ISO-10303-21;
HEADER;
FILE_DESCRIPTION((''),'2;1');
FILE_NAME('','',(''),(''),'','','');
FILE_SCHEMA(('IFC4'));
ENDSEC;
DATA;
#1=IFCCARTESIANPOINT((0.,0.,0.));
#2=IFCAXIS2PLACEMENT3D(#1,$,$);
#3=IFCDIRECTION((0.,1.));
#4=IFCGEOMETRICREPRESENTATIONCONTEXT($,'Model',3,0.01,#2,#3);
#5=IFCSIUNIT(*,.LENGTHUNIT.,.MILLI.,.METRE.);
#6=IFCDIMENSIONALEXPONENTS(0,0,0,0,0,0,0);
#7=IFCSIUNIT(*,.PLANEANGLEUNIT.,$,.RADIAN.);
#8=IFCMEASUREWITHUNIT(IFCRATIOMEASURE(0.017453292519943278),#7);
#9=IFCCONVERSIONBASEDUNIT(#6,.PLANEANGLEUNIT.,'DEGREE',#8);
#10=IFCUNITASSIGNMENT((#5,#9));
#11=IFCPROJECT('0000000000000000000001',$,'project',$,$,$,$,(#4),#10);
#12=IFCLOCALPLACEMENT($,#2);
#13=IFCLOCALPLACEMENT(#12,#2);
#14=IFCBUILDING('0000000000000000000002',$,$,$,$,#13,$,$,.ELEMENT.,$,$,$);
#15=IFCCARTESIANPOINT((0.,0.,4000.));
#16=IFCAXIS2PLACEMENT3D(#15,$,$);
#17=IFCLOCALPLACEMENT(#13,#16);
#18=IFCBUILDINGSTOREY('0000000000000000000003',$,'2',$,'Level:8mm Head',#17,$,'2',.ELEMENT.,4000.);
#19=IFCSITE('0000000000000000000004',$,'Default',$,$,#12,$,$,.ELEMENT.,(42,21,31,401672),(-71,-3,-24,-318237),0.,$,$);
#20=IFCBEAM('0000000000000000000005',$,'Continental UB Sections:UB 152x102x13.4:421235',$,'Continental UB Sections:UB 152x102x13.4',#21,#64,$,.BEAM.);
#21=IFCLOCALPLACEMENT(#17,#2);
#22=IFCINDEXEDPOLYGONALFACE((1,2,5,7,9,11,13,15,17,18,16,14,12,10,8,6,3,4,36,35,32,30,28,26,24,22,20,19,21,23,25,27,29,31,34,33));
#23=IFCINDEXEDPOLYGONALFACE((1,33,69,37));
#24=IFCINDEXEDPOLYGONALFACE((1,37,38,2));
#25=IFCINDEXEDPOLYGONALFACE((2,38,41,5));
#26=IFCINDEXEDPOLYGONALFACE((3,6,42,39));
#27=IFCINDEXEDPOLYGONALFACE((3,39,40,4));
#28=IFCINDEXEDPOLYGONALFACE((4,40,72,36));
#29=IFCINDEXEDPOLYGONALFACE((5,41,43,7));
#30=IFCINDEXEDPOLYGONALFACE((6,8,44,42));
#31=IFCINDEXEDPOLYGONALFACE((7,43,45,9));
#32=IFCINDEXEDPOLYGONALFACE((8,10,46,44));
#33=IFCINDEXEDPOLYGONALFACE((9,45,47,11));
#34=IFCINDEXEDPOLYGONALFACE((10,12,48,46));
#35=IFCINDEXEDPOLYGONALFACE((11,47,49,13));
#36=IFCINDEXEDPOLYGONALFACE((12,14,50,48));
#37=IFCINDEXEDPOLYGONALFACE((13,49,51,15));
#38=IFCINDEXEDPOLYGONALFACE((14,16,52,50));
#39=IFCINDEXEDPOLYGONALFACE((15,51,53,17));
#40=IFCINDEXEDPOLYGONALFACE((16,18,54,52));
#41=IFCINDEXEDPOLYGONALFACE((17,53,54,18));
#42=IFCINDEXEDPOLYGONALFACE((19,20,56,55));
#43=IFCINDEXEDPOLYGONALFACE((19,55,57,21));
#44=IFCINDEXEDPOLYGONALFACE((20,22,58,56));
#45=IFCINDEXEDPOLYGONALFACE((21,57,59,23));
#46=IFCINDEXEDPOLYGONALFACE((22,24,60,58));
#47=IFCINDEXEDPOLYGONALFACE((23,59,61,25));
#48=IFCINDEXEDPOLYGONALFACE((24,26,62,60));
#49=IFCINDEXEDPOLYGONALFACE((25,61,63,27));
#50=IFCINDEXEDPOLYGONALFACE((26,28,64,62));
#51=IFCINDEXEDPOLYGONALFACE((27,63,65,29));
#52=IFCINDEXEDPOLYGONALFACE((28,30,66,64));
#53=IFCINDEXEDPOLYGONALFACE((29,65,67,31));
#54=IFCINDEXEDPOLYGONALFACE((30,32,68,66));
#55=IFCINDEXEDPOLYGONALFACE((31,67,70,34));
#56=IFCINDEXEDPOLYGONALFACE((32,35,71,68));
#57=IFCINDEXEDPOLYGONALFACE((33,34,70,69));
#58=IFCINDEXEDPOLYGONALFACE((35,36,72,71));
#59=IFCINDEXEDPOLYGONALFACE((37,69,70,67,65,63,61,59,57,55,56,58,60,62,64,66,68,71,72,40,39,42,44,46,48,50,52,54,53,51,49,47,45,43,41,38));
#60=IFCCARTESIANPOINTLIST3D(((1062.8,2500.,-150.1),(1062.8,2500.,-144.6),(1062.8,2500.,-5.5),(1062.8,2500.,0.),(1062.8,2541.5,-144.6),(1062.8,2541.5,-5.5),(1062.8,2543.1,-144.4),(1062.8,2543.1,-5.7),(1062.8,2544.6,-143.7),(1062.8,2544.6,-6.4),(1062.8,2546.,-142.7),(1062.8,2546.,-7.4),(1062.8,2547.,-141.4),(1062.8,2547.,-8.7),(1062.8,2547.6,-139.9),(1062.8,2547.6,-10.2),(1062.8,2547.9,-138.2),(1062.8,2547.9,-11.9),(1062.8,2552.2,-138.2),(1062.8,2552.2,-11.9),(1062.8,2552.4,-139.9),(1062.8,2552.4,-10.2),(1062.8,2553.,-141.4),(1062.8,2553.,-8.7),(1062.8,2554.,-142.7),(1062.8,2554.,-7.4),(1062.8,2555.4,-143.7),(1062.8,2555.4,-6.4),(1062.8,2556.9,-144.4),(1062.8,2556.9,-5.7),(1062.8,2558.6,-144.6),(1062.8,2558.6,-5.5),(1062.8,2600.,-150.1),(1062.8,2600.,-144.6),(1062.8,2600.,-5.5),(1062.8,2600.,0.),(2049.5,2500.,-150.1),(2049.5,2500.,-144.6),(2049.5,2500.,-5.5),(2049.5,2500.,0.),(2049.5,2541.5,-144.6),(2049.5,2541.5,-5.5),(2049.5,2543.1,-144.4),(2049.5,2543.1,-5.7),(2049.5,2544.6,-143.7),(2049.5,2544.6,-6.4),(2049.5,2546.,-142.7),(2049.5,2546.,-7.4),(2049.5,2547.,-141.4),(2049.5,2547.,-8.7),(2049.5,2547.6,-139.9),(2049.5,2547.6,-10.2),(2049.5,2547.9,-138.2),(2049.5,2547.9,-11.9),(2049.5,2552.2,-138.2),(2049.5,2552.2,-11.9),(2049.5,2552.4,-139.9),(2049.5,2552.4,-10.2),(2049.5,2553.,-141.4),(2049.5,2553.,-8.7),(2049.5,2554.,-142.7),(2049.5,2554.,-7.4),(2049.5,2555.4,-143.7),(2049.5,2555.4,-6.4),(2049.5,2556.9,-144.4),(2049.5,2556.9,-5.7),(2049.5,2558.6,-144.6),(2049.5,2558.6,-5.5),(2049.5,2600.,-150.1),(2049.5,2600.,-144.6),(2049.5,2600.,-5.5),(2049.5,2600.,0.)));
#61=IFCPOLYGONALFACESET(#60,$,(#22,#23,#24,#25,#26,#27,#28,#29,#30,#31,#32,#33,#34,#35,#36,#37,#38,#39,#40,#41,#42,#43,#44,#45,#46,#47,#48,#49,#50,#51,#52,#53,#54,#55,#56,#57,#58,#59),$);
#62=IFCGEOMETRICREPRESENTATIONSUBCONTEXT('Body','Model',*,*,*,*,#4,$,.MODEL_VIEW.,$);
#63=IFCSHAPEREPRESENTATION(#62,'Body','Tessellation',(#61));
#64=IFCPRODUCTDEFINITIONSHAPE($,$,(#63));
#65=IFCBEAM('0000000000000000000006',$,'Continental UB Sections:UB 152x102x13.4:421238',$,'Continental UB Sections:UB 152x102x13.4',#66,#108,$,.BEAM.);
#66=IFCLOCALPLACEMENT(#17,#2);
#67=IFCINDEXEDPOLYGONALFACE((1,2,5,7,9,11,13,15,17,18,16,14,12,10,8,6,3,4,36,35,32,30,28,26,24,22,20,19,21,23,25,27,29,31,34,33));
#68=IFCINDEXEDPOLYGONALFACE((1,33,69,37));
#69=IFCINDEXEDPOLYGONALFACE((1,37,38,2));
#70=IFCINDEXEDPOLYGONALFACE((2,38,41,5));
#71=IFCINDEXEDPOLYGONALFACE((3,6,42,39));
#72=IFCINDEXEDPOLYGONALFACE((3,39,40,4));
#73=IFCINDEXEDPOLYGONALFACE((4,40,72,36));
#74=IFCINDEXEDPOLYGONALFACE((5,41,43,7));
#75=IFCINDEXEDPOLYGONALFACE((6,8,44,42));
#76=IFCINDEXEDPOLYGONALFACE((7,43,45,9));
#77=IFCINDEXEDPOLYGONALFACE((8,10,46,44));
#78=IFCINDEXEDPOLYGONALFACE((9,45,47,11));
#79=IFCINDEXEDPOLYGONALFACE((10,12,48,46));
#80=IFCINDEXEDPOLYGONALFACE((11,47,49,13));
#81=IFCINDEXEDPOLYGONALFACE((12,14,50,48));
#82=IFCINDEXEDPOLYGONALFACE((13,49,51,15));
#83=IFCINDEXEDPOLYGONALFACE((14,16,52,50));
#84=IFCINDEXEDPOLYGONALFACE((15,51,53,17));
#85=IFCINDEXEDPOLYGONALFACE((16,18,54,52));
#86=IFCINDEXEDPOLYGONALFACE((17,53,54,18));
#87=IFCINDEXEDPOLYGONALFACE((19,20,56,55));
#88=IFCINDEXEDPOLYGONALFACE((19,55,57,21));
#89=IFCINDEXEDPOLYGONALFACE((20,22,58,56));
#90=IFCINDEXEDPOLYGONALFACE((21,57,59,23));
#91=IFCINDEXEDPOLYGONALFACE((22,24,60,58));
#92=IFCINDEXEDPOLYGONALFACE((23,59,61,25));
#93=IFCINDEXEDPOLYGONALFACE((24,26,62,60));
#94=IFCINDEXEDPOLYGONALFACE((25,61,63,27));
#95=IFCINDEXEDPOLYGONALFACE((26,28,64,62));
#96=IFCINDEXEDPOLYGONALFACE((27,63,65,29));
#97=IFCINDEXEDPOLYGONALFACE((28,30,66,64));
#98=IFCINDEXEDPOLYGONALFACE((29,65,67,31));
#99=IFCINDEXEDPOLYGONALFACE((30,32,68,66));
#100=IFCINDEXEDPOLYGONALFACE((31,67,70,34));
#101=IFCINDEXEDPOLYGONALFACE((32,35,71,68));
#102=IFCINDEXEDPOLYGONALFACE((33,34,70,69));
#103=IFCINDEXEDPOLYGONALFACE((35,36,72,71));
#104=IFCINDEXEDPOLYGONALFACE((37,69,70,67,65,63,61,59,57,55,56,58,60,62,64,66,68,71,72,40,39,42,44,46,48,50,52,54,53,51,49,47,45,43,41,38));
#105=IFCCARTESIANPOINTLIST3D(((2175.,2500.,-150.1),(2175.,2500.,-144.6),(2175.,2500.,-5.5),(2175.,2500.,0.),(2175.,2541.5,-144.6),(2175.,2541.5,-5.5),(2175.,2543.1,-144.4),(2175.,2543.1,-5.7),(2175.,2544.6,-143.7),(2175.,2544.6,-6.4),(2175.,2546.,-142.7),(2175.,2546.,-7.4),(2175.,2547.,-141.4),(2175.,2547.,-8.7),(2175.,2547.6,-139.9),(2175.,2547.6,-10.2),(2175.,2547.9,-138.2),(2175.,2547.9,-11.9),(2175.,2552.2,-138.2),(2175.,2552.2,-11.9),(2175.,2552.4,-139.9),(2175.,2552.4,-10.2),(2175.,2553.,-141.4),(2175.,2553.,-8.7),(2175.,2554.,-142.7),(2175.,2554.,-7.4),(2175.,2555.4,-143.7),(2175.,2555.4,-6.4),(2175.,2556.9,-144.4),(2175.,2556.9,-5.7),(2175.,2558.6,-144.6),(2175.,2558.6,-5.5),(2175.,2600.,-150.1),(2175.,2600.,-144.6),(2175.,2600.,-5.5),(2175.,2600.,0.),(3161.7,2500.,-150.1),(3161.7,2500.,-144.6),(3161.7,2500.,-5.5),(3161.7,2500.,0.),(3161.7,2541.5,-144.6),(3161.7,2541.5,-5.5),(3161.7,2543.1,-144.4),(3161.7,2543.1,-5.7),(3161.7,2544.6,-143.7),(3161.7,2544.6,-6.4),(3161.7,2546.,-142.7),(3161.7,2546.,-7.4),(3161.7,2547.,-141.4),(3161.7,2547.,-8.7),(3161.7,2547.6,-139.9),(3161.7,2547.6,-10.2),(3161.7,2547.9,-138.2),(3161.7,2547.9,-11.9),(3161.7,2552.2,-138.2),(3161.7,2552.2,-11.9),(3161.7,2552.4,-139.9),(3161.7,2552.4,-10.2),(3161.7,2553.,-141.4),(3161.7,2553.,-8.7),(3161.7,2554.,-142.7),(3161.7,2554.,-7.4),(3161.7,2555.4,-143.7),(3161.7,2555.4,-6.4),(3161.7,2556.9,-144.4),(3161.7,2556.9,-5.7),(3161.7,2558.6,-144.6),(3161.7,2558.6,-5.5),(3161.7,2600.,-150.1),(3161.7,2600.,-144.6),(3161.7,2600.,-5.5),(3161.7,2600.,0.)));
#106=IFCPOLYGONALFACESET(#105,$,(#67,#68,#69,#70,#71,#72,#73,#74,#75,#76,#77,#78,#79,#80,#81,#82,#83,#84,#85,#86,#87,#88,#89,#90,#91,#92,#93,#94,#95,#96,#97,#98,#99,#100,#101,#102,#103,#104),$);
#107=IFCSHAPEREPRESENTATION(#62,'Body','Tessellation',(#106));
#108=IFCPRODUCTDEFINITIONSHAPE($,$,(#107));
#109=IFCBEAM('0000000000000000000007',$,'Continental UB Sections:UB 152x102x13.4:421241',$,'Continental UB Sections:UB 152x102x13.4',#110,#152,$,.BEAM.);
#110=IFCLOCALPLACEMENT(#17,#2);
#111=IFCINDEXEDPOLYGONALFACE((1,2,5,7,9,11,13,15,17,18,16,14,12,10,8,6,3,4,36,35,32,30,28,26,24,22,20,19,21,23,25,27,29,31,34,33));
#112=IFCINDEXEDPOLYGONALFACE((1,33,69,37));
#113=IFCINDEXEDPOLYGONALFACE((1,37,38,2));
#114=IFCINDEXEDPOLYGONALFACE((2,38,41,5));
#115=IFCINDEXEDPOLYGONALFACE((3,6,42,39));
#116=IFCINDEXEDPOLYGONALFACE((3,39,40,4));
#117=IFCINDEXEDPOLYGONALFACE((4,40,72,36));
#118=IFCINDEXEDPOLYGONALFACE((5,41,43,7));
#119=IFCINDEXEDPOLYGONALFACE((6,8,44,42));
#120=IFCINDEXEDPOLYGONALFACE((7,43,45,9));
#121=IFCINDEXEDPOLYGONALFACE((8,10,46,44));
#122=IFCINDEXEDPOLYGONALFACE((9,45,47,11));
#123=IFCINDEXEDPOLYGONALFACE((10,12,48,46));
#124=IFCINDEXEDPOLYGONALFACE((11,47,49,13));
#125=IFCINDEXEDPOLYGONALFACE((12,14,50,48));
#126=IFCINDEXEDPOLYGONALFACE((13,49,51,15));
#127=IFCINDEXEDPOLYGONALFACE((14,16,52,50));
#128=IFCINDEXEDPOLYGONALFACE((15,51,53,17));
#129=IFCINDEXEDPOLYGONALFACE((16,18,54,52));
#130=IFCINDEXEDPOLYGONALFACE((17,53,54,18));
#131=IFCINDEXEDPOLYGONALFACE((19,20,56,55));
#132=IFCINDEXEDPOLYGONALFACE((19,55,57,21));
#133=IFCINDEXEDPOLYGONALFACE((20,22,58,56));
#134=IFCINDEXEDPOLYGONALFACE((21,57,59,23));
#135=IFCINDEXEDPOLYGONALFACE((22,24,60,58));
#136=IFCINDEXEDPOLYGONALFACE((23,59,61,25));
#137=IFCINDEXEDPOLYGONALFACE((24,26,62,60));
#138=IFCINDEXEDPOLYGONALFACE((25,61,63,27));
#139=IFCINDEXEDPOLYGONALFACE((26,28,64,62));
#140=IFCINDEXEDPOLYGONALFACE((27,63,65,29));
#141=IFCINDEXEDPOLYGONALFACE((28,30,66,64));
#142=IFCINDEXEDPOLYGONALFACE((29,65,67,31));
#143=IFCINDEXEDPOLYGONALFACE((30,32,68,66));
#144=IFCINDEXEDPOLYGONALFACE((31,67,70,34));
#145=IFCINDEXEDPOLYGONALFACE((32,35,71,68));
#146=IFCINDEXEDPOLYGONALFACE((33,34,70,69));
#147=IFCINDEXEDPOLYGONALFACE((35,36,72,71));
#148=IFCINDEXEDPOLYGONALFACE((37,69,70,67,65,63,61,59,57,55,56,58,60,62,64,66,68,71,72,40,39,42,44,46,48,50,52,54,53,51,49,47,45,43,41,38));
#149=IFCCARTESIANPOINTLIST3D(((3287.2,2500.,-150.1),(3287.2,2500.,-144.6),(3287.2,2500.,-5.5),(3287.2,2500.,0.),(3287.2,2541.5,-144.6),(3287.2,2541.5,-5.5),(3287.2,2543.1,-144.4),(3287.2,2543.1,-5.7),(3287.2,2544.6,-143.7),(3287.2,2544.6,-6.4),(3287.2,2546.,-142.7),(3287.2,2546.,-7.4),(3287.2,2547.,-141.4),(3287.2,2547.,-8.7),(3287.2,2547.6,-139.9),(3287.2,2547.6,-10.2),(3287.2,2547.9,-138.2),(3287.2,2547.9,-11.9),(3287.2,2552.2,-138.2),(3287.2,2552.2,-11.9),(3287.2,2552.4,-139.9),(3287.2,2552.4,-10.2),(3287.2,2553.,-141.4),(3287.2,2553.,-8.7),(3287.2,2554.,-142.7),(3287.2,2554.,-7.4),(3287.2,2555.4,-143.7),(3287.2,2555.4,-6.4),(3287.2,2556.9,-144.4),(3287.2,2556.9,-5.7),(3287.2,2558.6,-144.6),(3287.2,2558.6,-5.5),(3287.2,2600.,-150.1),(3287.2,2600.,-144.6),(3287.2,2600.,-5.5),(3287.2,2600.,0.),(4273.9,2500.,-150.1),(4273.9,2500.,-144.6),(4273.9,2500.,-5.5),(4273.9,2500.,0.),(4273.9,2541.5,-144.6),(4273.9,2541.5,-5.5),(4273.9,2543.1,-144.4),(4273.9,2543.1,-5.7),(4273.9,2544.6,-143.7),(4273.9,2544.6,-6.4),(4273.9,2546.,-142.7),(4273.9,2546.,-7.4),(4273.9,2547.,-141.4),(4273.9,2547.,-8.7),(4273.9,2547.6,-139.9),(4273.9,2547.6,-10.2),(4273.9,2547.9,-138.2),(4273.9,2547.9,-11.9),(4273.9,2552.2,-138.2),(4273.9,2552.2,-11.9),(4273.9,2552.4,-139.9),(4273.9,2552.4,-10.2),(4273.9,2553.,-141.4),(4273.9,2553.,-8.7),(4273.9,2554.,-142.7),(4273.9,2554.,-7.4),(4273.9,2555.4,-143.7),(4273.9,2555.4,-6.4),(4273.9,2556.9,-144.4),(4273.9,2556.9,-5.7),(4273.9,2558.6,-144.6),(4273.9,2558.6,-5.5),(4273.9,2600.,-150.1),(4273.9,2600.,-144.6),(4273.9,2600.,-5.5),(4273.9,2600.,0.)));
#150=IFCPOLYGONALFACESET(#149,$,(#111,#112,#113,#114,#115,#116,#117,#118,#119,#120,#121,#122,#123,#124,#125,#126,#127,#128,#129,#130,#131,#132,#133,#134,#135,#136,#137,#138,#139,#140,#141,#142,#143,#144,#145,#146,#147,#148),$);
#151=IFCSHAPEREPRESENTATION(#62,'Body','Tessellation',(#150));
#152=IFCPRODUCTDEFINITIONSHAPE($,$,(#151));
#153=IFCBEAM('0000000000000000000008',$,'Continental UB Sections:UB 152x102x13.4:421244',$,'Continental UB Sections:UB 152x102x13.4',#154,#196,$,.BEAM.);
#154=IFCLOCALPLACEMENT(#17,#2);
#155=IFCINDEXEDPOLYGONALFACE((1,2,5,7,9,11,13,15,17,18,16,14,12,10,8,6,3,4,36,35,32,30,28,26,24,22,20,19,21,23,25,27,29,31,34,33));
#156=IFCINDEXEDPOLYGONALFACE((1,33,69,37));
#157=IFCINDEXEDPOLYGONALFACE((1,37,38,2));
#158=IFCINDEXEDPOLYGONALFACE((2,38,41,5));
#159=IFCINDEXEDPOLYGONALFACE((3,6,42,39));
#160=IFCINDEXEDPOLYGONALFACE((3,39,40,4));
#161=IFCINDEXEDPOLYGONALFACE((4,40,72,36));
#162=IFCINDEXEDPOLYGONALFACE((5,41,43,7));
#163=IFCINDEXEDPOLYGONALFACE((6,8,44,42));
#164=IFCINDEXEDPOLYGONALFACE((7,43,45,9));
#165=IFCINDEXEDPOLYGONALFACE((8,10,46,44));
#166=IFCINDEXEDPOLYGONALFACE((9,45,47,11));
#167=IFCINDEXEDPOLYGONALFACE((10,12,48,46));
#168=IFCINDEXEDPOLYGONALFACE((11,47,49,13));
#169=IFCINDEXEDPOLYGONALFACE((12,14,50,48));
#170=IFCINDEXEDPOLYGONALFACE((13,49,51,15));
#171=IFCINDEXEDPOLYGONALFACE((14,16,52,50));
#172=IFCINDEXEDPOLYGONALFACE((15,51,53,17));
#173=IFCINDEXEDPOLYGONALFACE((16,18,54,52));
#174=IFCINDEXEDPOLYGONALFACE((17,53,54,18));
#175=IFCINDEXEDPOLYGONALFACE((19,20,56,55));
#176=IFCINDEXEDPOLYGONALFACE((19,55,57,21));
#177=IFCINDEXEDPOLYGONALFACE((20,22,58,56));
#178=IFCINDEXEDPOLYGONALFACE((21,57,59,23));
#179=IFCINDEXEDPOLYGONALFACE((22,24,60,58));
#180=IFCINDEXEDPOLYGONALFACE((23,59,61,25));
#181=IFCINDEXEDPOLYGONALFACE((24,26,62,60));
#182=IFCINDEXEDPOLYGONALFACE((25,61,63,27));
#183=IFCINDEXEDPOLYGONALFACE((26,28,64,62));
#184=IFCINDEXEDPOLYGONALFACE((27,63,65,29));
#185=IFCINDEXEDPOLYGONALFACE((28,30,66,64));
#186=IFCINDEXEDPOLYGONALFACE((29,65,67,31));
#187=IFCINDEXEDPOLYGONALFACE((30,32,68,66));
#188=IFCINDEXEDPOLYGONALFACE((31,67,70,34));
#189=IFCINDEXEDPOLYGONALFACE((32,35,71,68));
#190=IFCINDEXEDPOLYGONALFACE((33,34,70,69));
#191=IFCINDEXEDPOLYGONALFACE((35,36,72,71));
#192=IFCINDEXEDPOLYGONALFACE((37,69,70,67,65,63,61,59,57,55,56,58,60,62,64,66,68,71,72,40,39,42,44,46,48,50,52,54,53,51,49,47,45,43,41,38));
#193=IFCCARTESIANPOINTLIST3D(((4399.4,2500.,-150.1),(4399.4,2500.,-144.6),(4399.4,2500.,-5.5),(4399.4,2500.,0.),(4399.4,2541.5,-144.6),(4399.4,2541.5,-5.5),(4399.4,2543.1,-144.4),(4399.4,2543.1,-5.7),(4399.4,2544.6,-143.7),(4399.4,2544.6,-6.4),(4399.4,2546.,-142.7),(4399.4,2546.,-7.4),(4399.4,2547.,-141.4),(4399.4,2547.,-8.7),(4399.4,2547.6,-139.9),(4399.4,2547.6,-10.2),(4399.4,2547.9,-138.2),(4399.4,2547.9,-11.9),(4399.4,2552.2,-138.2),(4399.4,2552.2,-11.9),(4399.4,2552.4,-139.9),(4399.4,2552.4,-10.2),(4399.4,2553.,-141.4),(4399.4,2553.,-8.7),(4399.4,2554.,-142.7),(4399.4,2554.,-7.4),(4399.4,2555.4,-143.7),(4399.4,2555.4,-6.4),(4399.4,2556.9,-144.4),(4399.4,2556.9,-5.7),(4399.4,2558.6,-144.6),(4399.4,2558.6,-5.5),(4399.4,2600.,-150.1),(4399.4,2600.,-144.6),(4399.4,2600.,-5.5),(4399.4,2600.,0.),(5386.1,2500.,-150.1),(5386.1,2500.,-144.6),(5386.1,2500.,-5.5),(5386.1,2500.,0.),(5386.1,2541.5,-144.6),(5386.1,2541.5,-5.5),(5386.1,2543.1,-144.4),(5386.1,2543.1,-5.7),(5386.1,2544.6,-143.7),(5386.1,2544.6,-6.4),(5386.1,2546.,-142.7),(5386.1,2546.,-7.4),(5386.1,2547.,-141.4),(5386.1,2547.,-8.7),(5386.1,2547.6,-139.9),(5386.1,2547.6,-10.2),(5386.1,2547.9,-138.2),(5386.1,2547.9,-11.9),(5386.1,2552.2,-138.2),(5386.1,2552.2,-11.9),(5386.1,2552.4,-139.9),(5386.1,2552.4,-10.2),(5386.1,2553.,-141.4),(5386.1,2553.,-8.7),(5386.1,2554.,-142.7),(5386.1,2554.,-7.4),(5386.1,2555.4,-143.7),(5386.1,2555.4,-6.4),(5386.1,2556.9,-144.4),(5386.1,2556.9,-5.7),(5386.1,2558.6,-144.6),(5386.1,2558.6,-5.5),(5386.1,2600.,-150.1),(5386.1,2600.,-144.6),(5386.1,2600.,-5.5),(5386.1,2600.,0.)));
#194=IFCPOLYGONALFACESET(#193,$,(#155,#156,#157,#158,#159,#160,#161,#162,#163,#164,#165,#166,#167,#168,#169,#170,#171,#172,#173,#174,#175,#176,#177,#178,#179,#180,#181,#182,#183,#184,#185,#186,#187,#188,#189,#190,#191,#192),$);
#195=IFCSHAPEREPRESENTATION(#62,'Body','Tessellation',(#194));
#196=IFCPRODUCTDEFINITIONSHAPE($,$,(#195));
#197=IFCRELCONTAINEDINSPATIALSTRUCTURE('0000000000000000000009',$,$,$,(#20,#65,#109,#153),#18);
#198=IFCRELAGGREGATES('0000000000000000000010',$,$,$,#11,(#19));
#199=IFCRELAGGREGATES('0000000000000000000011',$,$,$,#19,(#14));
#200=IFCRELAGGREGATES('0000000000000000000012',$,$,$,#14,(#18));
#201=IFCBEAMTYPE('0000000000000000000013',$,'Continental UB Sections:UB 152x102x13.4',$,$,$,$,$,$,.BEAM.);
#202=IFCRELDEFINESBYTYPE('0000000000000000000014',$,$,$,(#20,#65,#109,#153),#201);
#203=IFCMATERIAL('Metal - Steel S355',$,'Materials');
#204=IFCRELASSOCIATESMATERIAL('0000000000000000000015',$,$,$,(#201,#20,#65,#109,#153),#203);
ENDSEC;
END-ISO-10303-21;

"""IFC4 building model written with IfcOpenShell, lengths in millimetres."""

from ifc_helpers import new_model, entity, si_unit, converted_unit, direction, frame, origin, place, context, subcontext, project, spatial, line, arc, indexed_curve, outline, extrude, source, transform, mapped, material, type_object, type_shapes, element, save


model = new_model("IFC4")

# Units and contexts
model_context = context("Model", 3, precision=0.01, world=origin(), true_north=direction((0.0, 1.0)))
body_context = subcontext(model_context, "Body", "Model", "MODEL_VIEW")
ifc_project = project(units=[si_unit("LENGTHUNIT", "METRE", prefix="MILLI"), converted_unit("PLANEANGLEUNIT", "DEGREE", entity("IfcRatioMeasure", 0.017453292519943278), si_unit("PLANEANGLEUNIT", "RADIAN"), dimensions=[0, 0, 0, 0, 0, 0, 0])], contexts=[model_context])

# Site, building, storey
site_placement = place(None, origin())
site = spatial("IfcSite", under=ifc_project, at=site_placement, Name="Default", CompositionType="ELEMENT", RefLatitude=(42, 21, 31, 401672), RefLongitude=(-71, -3, -24, -318237), RefElevation=0.0)
building_placement = place(site_placement, origin())
building = spatial("IfcBuilding", under=site, at=building_placement, CompositionType="ELEMENT")
storey_placement = place(building_placement, frame((0.0, 0.0, 4000.0)))
storey = spatial("IfcBuildingStorey", under=building, at=storey_placement, Name="2", ObjectType="Level:8mm Head", LongName="2", CompositionType="ELEMENT", Elevation=4000.0)

# Beams
ifc_material = material(Name="Metal - Steel S355", Category="Materials")
beam_type_1 = type_object("IfcBeamType", Name="Continental UB Sections:UB 152x102x13.4", PredefinedType="BEAM", material=ifc_material)
shared_shape_1 = source(origin(), body_context, "Body", "SweptSolid", [
    extrude(outline(indexed_curve([(-75.0, -50.1), (-69.6, -50.1), (-69.6, -8.5), (-67.7, -4.0), (-63.2, -2.1), (63.1, -2.1), (67.7, -4.0), (69.5, -8.5), (69.5, -50.1), (75.1, -50.1), (75.1, 50.1), (69.5, 50.1), (69.5, 8.6), (67.7, 4.0), (63.1, 2.2), (-63.2, 2.2), (-67.7, 4.0), (-69.6, 8.6), (-69.6, 50.0), (-75.0, 50.0)], segments=[line(1, 2, 3), arc(3, 4, 5), line(5, 6), arc(6, 7, 8), line(8, 9, 10, 11, 12, 13), arc(13, 14, 15), line(15, 16), arc(16, 17, 18), line(18, 19, 20, 1)], self_intersect=False)), frame((-493.3, 0.0, 0.0), z_axis=(1.0, 0.0, 0.0), x_axis=(0.0, 0.0, -1.0)), (0.0, 0.0, 1.0), 986.7),
])
type_shapes(beam_type_1, [shared_shape_1])
for number, where, name in (
    (1, (1556.1, 2550.0, -75.1), "Continental UB Sections:UB 152x102x13.4:421235"),
    (2, (2668.3, 2550.0, -75.1), "Continental UB Sections:UB 152x102x13.4:421238"),
    (3, (3780.6, 2550.0, -75.1), "Continental UB Sections:UB 152x102x13.4:421241"),
    (4, (4892.8, 2550.0, -75.1), "Continental UB Sections:UB 152x102x13.4:421244"),
):
    element("IfcBeam", number, at=place(storey_placement, frame(where)), inside=storey, type_object=beam_type_1, material=ifc_material, Name=name, ObjectType="Continental UB Sections:UB 152x102x13.4", PredefinedType="BEAM", context=body_context, shape_type="MappedRepresentation", body=[
        mapped(shared_shape_1, transform((0.0, 0.0, 0.0), scale=1.0)),
    ])

save(model, "model.ifc")
